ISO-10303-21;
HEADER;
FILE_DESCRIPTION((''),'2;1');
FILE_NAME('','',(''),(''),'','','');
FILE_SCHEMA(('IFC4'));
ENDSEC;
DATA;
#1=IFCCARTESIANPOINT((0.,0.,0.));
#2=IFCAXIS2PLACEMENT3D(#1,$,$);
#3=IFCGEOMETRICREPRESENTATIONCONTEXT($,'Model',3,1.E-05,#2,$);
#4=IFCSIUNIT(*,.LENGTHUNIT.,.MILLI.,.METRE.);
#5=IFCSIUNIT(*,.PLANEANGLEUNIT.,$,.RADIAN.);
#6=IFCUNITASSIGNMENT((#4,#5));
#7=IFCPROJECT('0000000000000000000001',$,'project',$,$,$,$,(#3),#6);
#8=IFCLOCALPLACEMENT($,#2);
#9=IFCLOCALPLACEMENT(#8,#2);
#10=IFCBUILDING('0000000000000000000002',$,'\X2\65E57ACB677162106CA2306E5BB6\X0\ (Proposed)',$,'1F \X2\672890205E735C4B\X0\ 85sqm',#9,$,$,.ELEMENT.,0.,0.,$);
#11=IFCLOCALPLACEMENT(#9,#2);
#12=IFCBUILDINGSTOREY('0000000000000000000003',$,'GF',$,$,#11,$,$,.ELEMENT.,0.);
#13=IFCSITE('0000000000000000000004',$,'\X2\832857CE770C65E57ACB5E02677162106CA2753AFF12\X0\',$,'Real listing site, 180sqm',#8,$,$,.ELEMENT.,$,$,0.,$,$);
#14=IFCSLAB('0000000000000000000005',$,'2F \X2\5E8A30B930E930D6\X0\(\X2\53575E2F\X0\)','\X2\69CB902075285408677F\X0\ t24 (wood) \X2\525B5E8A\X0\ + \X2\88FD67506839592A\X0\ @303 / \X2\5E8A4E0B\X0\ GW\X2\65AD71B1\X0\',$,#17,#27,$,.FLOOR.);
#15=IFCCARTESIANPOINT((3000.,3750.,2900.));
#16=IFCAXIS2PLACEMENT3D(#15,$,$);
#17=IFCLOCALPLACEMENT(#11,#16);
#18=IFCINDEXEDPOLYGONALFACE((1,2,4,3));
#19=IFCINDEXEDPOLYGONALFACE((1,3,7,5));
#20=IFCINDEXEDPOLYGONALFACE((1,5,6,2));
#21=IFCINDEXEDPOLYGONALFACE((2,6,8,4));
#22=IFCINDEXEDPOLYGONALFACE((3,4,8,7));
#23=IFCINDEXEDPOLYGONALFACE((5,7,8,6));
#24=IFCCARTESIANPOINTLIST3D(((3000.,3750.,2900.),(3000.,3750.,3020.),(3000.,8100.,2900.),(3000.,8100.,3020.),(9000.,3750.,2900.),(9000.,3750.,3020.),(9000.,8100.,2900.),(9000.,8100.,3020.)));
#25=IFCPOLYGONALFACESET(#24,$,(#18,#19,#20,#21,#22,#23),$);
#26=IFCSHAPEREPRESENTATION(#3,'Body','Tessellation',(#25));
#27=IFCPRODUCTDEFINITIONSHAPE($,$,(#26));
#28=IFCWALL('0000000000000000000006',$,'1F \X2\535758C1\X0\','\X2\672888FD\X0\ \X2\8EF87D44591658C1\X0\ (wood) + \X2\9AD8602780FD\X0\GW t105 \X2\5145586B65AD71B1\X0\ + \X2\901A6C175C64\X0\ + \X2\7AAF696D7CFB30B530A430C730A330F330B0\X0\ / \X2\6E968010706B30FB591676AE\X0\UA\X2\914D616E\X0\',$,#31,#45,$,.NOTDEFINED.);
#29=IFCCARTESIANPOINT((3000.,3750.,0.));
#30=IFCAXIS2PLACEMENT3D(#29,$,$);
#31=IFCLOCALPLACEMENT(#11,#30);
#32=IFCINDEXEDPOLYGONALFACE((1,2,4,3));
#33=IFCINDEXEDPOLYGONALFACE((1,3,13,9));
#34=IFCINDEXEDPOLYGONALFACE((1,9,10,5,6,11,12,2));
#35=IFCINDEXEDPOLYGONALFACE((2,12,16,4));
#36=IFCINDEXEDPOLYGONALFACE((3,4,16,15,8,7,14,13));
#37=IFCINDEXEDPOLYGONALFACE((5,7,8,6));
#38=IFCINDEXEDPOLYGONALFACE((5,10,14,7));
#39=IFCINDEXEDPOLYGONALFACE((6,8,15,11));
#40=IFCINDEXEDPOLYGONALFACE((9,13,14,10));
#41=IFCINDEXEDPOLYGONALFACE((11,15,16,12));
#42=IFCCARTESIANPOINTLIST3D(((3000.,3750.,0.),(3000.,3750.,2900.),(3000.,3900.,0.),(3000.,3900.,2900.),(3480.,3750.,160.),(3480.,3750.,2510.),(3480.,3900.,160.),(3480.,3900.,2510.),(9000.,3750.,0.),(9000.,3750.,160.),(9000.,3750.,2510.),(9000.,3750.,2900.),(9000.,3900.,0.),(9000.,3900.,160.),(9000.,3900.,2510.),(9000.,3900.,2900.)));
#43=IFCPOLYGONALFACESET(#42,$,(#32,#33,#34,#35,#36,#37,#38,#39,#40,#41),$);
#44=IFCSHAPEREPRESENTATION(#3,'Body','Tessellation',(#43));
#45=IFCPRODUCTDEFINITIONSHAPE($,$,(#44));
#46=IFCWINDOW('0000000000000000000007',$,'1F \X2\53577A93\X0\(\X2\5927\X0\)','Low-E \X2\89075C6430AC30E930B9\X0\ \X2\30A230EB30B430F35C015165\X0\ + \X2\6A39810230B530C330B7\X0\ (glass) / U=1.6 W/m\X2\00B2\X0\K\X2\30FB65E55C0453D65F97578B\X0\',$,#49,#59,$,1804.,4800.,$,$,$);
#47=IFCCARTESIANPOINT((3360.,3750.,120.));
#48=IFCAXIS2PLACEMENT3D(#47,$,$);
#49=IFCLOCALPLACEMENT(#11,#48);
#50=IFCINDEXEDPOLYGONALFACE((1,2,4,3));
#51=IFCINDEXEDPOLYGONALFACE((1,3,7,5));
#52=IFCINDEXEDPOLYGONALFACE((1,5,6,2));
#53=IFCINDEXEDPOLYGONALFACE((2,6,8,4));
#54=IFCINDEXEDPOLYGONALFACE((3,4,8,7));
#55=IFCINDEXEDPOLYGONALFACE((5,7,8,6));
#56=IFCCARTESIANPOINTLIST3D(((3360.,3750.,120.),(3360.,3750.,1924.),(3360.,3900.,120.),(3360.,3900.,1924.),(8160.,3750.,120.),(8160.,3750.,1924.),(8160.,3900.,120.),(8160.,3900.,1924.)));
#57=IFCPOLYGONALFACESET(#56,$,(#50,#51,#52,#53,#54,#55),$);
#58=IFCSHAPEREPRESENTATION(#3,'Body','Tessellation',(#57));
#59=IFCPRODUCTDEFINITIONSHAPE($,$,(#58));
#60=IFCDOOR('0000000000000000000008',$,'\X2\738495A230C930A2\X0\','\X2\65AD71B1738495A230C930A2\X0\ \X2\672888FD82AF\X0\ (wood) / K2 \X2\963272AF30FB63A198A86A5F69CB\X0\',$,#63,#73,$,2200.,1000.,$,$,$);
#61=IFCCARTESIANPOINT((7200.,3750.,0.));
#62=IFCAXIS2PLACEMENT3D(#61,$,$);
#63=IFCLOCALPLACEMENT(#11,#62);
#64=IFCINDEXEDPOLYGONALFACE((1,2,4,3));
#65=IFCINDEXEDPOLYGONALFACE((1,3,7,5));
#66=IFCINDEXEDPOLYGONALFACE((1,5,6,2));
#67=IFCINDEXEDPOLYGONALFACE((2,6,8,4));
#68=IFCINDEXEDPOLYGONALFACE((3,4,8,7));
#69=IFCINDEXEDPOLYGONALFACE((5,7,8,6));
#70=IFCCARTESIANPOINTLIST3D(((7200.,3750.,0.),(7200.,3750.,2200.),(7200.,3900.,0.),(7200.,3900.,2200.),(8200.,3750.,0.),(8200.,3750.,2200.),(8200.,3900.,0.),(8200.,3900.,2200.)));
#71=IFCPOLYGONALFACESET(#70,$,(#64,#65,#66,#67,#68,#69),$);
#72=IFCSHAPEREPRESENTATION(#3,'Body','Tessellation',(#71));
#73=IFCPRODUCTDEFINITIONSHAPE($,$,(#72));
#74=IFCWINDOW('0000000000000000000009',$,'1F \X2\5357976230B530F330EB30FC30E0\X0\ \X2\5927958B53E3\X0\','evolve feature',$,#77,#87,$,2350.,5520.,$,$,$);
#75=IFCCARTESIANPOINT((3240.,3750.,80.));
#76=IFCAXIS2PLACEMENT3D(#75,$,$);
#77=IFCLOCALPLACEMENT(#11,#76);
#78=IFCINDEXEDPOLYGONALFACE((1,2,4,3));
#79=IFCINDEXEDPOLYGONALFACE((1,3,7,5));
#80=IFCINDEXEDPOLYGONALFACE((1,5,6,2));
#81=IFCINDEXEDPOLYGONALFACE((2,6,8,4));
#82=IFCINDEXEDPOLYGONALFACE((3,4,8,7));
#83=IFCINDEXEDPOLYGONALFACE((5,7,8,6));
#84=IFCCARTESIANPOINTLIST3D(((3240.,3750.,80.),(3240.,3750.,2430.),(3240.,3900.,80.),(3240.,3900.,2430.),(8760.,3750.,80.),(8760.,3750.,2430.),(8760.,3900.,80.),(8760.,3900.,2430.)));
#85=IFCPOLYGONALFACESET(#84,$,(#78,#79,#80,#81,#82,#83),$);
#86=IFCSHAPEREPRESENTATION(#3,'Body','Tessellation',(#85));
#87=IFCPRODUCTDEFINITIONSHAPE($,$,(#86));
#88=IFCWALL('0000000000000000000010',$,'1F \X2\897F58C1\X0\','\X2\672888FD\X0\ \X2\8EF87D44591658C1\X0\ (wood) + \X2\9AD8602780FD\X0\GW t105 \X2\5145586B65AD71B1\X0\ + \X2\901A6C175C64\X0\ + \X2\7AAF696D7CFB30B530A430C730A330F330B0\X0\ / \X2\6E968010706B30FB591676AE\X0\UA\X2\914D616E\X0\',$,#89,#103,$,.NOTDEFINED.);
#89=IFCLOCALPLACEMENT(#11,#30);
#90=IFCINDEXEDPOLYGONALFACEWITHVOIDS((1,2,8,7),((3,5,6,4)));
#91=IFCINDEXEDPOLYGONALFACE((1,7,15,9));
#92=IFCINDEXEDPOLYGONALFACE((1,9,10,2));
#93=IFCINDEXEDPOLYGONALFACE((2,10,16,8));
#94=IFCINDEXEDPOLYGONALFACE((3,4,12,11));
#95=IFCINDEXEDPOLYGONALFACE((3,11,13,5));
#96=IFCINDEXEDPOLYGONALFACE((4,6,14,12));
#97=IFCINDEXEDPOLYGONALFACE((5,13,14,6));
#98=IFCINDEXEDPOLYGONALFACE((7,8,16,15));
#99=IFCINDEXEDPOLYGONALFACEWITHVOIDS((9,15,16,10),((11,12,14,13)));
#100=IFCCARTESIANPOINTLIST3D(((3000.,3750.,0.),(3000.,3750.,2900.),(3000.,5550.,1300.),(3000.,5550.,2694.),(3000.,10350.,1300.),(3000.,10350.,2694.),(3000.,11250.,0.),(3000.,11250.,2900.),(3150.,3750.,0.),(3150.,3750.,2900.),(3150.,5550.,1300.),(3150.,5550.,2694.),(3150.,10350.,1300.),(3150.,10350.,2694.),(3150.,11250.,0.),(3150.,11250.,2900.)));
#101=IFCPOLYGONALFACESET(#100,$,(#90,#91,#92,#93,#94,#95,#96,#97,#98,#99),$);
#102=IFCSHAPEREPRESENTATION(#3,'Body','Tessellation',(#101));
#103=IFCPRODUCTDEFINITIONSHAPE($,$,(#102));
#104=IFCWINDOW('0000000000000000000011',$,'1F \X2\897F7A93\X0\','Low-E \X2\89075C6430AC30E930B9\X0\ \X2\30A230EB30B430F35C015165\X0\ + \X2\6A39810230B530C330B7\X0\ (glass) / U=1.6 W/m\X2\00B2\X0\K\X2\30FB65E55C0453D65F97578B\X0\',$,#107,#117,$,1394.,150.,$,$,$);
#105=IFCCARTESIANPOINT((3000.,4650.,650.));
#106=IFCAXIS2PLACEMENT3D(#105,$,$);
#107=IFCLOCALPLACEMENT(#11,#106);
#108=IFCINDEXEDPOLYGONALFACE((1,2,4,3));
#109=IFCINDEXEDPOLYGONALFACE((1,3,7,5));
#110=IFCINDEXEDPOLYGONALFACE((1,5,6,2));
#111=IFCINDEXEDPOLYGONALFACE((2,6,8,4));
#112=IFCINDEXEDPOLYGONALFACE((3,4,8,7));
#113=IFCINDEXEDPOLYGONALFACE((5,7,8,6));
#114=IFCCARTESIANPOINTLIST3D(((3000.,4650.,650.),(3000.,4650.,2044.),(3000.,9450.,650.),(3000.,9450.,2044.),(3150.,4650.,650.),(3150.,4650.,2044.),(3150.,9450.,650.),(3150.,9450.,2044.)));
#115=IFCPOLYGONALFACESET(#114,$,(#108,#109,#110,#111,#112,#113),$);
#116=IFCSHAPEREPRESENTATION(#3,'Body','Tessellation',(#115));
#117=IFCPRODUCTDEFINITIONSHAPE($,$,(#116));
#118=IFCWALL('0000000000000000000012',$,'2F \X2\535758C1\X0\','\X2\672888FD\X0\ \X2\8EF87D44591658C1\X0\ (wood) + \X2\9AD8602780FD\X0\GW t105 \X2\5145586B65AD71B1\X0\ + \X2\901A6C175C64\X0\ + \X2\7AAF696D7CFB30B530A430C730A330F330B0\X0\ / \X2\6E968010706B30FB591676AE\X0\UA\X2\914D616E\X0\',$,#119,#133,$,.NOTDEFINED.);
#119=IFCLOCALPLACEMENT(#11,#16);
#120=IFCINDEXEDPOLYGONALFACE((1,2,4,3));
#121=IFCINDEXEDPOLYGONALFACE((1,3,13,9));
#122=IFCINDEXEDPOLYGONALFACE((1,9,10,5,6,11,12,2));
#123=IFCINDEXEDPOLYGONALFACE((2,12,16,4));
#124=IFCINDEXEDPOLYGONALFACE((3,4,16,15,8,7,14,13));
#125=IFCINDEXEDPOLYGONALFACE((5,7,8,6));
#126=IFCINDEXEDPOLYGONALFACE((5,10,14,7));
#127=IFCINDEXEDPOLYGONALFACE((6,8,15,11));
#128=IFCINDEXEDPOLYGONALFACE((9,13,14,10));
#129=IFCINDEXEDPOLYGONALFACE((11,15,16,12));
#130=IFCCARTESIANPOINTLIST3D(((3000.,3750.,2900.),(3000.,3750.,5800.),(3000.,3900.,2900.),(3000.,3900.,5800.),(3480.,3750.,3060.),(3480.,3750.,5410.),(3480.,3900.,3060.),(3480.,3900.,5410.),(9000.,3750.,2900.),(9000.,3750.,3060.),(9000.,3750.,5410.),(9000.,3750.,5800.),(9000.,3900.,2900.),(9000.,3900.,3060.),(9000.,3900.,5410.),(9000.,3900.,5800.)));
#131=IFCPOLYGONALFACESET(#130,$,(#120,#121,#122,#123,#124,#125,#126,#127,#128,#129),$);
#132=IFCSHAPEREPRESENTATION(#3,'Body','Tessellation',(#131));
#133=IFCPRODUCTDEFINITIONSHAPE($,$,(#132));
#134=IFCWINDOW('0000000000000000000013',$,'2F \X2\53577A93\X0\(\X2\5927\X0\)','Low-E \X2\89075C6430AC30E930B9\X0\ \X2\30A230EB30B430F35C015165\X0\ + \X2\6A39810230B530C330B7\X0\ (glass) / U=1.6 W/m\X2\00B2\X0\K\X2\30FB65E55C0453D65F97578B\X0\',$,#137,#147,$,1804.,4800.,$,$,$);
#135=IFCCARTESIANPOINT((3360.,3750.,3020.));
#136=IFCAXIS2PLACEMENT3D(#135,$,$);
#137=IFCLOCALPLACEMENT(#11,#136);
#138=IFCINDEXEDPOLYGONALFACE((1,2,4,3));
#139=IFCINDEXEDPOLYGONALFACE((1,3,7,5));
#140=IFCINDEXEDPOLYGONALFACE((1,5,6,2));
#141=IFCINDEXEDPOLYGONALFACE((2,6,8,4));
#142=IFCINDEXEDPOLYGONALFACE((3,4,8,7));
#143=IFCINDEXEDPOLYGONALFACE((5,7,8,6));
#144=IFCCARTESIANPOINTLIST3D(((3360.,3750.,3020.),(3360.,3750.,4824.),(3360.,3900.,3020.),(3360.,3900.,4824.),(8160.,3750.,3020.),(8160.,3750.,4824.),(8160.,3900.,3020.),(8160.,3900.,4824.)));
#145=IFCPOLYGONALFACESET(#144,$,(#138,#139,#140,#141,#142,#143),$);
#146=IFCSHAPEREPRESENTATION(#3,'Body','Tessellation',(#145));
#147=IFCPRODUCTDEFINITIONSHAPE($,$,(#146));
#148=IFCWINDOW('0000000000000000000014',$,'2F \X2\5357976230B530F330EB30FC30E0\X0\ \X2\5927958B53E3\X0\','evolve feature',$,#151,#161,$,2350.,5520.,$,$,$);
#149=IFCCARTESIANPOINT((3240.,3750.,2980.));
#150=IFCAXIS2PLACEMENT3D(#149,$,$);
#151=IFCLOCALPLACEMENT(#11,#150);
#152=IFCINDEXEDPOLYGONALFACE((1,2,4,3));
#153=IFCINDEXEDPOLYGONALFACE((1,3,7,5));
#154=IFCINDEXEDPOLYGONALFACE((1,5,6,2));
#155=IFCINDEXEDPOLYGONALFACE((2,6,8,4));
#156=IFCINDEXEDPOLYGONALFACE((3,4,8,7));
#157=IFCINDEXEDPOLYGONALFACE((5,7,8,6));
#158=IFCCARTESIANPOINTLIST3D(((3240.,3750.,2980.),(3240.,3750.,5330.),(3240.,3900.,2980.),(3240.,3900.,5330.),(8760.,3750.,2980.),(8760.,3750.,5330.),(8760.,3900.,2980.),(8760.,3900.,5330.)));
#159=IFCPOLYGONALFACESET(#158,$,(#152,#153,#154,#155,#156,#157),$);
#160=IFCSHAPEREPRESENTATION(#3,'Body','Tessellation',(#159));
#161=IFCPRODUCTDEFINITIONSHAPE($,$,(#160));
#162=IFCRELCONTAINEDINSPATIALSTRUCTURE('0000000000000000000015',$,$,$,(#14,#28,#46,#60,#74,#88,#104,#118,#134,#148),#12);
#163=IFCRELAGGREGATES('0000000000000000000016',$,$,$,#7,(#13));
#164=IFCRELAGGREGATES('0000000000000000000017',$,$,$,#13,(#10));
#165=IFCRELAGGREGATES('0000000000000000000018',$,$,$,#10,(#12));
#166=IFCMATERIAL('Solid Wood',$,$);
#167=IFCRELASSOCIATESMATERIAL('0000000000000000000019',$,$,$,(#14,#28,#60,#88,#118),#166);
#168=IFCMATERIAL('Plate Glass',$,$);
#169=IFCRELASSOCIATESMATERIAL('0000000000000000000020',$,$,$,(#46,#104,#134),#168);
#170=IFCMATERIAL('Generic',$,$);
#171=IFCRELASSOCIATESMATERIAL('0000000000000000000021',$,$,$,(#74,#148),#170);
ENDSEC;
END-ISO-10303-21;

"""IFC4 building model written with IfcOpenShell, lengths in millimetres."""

from ifc_helpers import new_model, si_unit, frame, frame_2d, origin, place, context, project, spatial, rectangle, extrude, material, element, fill, save


model = new_model("IFC4")

# Units and contexts
model_context = context("Model", 3, precision=1e-05, world=origin())
ifc_project = project(units=[si_unit("LENGTHUNIT", "METRE", prefix="MILLI"), si_unit("PLANEANGLEUNIT", "RADIAN")], contexts=[model_context])

# Site, building, storey
site_placement = place(None, origin())
site = spatial("IfcSite", under=ifc_project, at=site_placement, Name="茨城県日立市東成沢町２", ObjectType="Real listing site, 180sqm", CompositionType="ELEMENT", RefElevation=0.0)
building_placement = place(site_placement, origin())
building = spatial("IfcBuilding", under=site, at=building_placement, Name="日立東成沢の家 (Proposed)", ObjectType="1F 木造平屋 85sqm", CompositionType="ELEMENT", ElevationOfRefHeight=0.0, ElevationOfTerrain=0.0)
storey_placement = place(building_placement, origin())
storey = spatial("IfcBuildingStorey", under=building, at=storey_placement, Name="GF", CompositionType="ELEMENT", Elevation=0.0)

# Slab
ifc_material_1 = material(Name="Solid Wood")
slab_1_placement = place(storey_placement, frame((3000.0, 3750.0, 2900.0)))
element("IfcSlab", 1, at=slab_1_placement, inside=storey, material=ifc_material_1, Name="2F 床スラブ(南帯)", Description="構造用合板 t24 (wood) 剛床 + 製材根太 @303 / 床下 GW断熱", PredefinedType="FLOOR", context=model_context, shape_type="SweptSolid", body=[
    extrude(rectangle(XDim=6000.0, YDim=4350.0, at=frame_2d((3000.0, 2175.0))), frame((3000.0, 3750.0, 2900.0)), (0.0, 0.0, 1.0), 120.0),
])
ifc_material_2 = material(Name="Generic")

# Wall, openings, windows, door
wall_1_placement = place(storey_placement, frame((3000.0, 3750.0, 0.0)))
wall_1 = element("IfcWall", 2, at=wall_1_placement, inside=storey, material=ifc_material_1, Name="1F 南壁", Description="木製 軸組外壁 (wood) + 高性能GW t105 充填断熱 + 通気層 + 窯業系サイディング / 準耐火・外皮UA配慮", PredefinedType="NOTDEFINED", context=model_context, shape_type="SweptSolid", body=[
    extrude(rectangle(XDim=6000.0, YDim=150.0, at=frame_2d((3000.0, 75.0))), frame((3000.0, 3750.0, 0.0)), (0.0, 0.0, 1.0), 2900.0),
])
opening_1_placement = place(storey_placement, frame((3360.0, 3750.0, 120.0)))
opening_1 = element("IfcOpeningElement", 3, at=opening_1_placement, cuts=wall_1, PredefinedType="NOTDEFINED", context=model_context, shape_type="SweptSolid", body=[
    extrude(rectangle(XDim=4800.0, YDim=150.0, at=frame_2d((2400.0, 75.0))), frame((3360.0, 3750.0, 120.0)), (0.0, 0.0, 1.0), 1804.0),
])
opening_2_placement = place(storey_placement, frame((7200.0, 3750.0, 0.0)))
opening_2 = element("IfcOpeningElement", 4, at=opening_2_placement, cuts=wall_1, PredefinedType="NOTDEFINED", context=model_context, shape_type="SweptSolid", body=[
    extrude(rectangle(XDim=1000.0, YDim=150.0, at=frame_2d((500.0, 75.0))), frame((7200.0, 3750.0, 0.0)), (0.0, 0.0, 1.0), 2200.0),
])
opening_3_placement = place(storey_placement, frame((3240.0, 3750.0, 80.0)))
opening_3 = element("IfcOpeningElement", 5, at=opening_3_placement, cuts=wall_1, PredefinedType="NOTDEFINED", context=model_context, shape_type="SweptSolid", body=[
    extrude(rectangle(XDim=5520.0, YDim=150.0, at=frame_2d((2760.0, 75.0))), frame((3240.0, 3750.0, 80.0)), (0.0, 0.0, 1.0), 2350.0),
])
ifc_material_3 = material(Name="Plate Glass")
window_1_placement = place(storey_placement, frame((3360.0, 3750.0, 120.0)))
window_1 = element("IfcWindow", 6, at=window_1_placement, inside=storey, material=ifc_material_3, Name="1F 南窓(大)", Description="Low-E 複層ガラス アルゴン封入 + 樹脂サッシ (glass) / U=1.6 W/m²K・日射取得型", OverallHeight=1804.0, OverallWidth=4800.0, context=model_context, shape_type="SweptSolid", body=[
    extrude(rectangle(XDim=4800.0, YDim=150.0, at=frame_2d((2400.0, 75.0))), frame((3360.0, 3750.0, 120.0)), (0.0, 0.0, 1.0), 1804.0),
])
fill(opening_1, window_1)
door_placement = place(storey_placement, frame((7200.0, 3750.0, 0.0)))
door = element("IfcDoor", 7, at=door_placement, inside=storey, material=ifc_material_1, Name="玄関ドア", Description="断熱玄関ドア 木製芯 (wood) / K2 防犯・採風機構", OverallHeight=2200.0, OverallWidth=1000.0, context=model_context, shape_type="SweptSolid", body=[
    extrude(rectangle(XDim=1000.0, YDim=150.0, at=frame_2d((500.0, 75.0))), frame((7200.0, 3750.0, 0.0)), (0.0, 0.0, 1.0), 2200.0),
])
fill(opening_2, door)
window_2_placement = place(storey_placement, frame((3240.0, 3750.0, 80.0)))
window_2 = element("IfcWindow", 8, at=window_2_placement, inside=storey, material=ifc_material_2, Name="1F 南面サンルーム 大開口", Description="evolve feature", OverallHeight=2350.0, OverallWidth=5520.0, context=model_context, shape_type="SweptSolid", body=[
    extrude(rectangle(XDim=5520.0, YDim=150.0, at=frame_2d((2760.0, 75.0))), frame((3240.0, 3750.0, 80.0)), (0.0, 0.0, 1.0), 2350.0),
])
fill(opening_3, window_2)

# Wall, opening, window
wall_2_placement = place(storey_placement, frame((3000.0, 3750.0, 0.0)))
wall_2 = element("IfcWall", 9, at=wall_2_placement, inside=storey, material=ifc_material_1, Name="1F 西壁", Description="木製 軸組外壁 (wood) + 高性能GW t105 充填断熱 + 通気層 + 窯業系サイディング / 準耐火・外皮UA配慮", PredefinedType="NOTDEFINED", context=model_context, shape_type="SweptSolid", body=[
    extrude(rectangle(XDim=150.0, YDim=7500.0, at=frame_2d((75.0, 3750.0))), frame((3000.0, 3750.0, 0.0)), (0.0, 0.0, 1.0), 2900.0),
])
opening_4_placement = place(storey_placement, frame((3000.0, 4650.0, 650.0)))
opening_4 = element("IfcOpeningElement", 10, at=opening_4_placement, cuts=wall_2, PredefinedType="NOTDEFINED", context=model_context, shape_type="SweptSolid", body=[
    extrude(rectangle(XDim=150.0, YDim=4800.0, at=frame_2d((75.0, 2400.0))), frame((3000.0, 4650.0, 650.0)), (0.0, 0.0, 1.0), 1394.0),
])
window_3_placement = place(storey_placement, frame((3000.0, 4650.0, 650.0)))
window_3 = element("IfcWindow", 11, at=window_3_placement, inside=storey, material=ifc_material_3, Name="1F 西窓", Description="Low-E 複層ガラス アルゴン封入 + 樹脂サッシ (glass) / U=1.6 W/m²K・日射取得型", OverallHeight=1394.0, OverallWidth=150.0, context=model_context, shape_type="SweptSolid", body=[
    extrude(rectangle(XDim=150.0, YDim=4800.0, at=frame_2d((75.0, 2400.0))), frame((3000.0, 4650.0, 650.0)), (0.0, 0.0, 1.0), 1394.0),
])
fill(opening_4, window_3)

# Wall, openings, windows
wall_3_placement = place(storey_placement, frame((3000.0, 3750.0, 2900.0)))
wall_3 = element("IfcWall", 12, at=wall_3_placement, inside=storey, material=ifc_material_1, Name="2F 南壁", Description="木製 軸組外壁 (wood) + 高性能GW t105 充填断熱 + 通気層 + 窯業系サイディング / 準耐火・外皮UA配慮", PredefinedType="NOTDEFINED", context=model_context, shape_type="SweptSolid", body=[
    extrude(rectangle(XDim=6000.0, YDim=150.0, at=frame_2d((3000.0, 75.0))), frame((3000.0, 3750.0, 2900.0)), (0.0, 0.0, 1.0), 2900.0),
])
opening_5_placement = place(storey_placement, frame((3360.0, 3750.0, 3020.0)))
opening_5 = element("IfcOpeningElement", 13, at=opening_5_placement, cuts=wall_3, PredefinedType="NOTDEFINED", context=model_context, shape_type="SweptSolid", body=[
    extrude(rectangle(XDim=4800.0, YDim=150.0, at=frame_2d((2400.0, 75.0))), frame((3360.0, 3750.0, 3020.0)), (0.0, 0.0, 1.0), 1804.0),
])
opening_6_placement = place(storey_placement, frame((3240.0, 3750.0, 2980.0)))
opening_6 = element("IfcOpeningElement", 14, at=opening_6_placement, cuts=wall_3, PredefinedType="NOTDEFINED", context=model_context, shape_type="SweptSolid", body=[
    extrude(rectangle(XDim=5520.0, YDim=150.0, at=frame_2d((2760.0, 75.0))), frame((3240.0, 3750.0, 2980.0)), (0.0, 0.0, 1.0), 2350.0),
])
window_4_placement = place(storey_placement, frame((3360.0, 3750.0, 3020.0)))
window_4 = element("IfcWindow", 15, at=window_4_placement, inside=storey, material=ifc_material_3, Name="2F 南窓(大)", Description="Low-E 複層ガラス アルゴン封入 + 樹脂サッシ (glass) / U=1.6 W/m²K・日射取得型", OverallHeight=1804.0, OverallWidth=4800.0, context=model_context, shape_type="SweptSolid", body=[
    extrude(rectangle(XDim=4800.0, YDim=150.0, at=frame_2d((2400.0, 75.0))), frame((3360.0, 3750.0, 3020.0)), (0.0, 0.0, 1.0), 1804.0),
])
fill(opening_5, window_4)
window_5_placement = place(storey_placement, frame((3240.0, 3750.0, 2980.0)))
window_5 = element("IfcWindow", 16, at=window_5_placement, inside=storey, material=ifc_material_2, Name="2F 南面サンルーム 大開口", Description="evolve feature", OverallHeight=2350.0, OverallWidth=5520.0, context=model_context, shape_type="SweptSolid", body=[
    extrude(rectangle(XDim=5520.0, YDim=150.0, at=frame_2d((2760.0, 75.0))), frame((3240.0, 3750.0, 2980.0)), (0.0, 0.0, 1.0), 2350.0),
])
fill(opening_6, window_5)

save(model, "model.ifc")
